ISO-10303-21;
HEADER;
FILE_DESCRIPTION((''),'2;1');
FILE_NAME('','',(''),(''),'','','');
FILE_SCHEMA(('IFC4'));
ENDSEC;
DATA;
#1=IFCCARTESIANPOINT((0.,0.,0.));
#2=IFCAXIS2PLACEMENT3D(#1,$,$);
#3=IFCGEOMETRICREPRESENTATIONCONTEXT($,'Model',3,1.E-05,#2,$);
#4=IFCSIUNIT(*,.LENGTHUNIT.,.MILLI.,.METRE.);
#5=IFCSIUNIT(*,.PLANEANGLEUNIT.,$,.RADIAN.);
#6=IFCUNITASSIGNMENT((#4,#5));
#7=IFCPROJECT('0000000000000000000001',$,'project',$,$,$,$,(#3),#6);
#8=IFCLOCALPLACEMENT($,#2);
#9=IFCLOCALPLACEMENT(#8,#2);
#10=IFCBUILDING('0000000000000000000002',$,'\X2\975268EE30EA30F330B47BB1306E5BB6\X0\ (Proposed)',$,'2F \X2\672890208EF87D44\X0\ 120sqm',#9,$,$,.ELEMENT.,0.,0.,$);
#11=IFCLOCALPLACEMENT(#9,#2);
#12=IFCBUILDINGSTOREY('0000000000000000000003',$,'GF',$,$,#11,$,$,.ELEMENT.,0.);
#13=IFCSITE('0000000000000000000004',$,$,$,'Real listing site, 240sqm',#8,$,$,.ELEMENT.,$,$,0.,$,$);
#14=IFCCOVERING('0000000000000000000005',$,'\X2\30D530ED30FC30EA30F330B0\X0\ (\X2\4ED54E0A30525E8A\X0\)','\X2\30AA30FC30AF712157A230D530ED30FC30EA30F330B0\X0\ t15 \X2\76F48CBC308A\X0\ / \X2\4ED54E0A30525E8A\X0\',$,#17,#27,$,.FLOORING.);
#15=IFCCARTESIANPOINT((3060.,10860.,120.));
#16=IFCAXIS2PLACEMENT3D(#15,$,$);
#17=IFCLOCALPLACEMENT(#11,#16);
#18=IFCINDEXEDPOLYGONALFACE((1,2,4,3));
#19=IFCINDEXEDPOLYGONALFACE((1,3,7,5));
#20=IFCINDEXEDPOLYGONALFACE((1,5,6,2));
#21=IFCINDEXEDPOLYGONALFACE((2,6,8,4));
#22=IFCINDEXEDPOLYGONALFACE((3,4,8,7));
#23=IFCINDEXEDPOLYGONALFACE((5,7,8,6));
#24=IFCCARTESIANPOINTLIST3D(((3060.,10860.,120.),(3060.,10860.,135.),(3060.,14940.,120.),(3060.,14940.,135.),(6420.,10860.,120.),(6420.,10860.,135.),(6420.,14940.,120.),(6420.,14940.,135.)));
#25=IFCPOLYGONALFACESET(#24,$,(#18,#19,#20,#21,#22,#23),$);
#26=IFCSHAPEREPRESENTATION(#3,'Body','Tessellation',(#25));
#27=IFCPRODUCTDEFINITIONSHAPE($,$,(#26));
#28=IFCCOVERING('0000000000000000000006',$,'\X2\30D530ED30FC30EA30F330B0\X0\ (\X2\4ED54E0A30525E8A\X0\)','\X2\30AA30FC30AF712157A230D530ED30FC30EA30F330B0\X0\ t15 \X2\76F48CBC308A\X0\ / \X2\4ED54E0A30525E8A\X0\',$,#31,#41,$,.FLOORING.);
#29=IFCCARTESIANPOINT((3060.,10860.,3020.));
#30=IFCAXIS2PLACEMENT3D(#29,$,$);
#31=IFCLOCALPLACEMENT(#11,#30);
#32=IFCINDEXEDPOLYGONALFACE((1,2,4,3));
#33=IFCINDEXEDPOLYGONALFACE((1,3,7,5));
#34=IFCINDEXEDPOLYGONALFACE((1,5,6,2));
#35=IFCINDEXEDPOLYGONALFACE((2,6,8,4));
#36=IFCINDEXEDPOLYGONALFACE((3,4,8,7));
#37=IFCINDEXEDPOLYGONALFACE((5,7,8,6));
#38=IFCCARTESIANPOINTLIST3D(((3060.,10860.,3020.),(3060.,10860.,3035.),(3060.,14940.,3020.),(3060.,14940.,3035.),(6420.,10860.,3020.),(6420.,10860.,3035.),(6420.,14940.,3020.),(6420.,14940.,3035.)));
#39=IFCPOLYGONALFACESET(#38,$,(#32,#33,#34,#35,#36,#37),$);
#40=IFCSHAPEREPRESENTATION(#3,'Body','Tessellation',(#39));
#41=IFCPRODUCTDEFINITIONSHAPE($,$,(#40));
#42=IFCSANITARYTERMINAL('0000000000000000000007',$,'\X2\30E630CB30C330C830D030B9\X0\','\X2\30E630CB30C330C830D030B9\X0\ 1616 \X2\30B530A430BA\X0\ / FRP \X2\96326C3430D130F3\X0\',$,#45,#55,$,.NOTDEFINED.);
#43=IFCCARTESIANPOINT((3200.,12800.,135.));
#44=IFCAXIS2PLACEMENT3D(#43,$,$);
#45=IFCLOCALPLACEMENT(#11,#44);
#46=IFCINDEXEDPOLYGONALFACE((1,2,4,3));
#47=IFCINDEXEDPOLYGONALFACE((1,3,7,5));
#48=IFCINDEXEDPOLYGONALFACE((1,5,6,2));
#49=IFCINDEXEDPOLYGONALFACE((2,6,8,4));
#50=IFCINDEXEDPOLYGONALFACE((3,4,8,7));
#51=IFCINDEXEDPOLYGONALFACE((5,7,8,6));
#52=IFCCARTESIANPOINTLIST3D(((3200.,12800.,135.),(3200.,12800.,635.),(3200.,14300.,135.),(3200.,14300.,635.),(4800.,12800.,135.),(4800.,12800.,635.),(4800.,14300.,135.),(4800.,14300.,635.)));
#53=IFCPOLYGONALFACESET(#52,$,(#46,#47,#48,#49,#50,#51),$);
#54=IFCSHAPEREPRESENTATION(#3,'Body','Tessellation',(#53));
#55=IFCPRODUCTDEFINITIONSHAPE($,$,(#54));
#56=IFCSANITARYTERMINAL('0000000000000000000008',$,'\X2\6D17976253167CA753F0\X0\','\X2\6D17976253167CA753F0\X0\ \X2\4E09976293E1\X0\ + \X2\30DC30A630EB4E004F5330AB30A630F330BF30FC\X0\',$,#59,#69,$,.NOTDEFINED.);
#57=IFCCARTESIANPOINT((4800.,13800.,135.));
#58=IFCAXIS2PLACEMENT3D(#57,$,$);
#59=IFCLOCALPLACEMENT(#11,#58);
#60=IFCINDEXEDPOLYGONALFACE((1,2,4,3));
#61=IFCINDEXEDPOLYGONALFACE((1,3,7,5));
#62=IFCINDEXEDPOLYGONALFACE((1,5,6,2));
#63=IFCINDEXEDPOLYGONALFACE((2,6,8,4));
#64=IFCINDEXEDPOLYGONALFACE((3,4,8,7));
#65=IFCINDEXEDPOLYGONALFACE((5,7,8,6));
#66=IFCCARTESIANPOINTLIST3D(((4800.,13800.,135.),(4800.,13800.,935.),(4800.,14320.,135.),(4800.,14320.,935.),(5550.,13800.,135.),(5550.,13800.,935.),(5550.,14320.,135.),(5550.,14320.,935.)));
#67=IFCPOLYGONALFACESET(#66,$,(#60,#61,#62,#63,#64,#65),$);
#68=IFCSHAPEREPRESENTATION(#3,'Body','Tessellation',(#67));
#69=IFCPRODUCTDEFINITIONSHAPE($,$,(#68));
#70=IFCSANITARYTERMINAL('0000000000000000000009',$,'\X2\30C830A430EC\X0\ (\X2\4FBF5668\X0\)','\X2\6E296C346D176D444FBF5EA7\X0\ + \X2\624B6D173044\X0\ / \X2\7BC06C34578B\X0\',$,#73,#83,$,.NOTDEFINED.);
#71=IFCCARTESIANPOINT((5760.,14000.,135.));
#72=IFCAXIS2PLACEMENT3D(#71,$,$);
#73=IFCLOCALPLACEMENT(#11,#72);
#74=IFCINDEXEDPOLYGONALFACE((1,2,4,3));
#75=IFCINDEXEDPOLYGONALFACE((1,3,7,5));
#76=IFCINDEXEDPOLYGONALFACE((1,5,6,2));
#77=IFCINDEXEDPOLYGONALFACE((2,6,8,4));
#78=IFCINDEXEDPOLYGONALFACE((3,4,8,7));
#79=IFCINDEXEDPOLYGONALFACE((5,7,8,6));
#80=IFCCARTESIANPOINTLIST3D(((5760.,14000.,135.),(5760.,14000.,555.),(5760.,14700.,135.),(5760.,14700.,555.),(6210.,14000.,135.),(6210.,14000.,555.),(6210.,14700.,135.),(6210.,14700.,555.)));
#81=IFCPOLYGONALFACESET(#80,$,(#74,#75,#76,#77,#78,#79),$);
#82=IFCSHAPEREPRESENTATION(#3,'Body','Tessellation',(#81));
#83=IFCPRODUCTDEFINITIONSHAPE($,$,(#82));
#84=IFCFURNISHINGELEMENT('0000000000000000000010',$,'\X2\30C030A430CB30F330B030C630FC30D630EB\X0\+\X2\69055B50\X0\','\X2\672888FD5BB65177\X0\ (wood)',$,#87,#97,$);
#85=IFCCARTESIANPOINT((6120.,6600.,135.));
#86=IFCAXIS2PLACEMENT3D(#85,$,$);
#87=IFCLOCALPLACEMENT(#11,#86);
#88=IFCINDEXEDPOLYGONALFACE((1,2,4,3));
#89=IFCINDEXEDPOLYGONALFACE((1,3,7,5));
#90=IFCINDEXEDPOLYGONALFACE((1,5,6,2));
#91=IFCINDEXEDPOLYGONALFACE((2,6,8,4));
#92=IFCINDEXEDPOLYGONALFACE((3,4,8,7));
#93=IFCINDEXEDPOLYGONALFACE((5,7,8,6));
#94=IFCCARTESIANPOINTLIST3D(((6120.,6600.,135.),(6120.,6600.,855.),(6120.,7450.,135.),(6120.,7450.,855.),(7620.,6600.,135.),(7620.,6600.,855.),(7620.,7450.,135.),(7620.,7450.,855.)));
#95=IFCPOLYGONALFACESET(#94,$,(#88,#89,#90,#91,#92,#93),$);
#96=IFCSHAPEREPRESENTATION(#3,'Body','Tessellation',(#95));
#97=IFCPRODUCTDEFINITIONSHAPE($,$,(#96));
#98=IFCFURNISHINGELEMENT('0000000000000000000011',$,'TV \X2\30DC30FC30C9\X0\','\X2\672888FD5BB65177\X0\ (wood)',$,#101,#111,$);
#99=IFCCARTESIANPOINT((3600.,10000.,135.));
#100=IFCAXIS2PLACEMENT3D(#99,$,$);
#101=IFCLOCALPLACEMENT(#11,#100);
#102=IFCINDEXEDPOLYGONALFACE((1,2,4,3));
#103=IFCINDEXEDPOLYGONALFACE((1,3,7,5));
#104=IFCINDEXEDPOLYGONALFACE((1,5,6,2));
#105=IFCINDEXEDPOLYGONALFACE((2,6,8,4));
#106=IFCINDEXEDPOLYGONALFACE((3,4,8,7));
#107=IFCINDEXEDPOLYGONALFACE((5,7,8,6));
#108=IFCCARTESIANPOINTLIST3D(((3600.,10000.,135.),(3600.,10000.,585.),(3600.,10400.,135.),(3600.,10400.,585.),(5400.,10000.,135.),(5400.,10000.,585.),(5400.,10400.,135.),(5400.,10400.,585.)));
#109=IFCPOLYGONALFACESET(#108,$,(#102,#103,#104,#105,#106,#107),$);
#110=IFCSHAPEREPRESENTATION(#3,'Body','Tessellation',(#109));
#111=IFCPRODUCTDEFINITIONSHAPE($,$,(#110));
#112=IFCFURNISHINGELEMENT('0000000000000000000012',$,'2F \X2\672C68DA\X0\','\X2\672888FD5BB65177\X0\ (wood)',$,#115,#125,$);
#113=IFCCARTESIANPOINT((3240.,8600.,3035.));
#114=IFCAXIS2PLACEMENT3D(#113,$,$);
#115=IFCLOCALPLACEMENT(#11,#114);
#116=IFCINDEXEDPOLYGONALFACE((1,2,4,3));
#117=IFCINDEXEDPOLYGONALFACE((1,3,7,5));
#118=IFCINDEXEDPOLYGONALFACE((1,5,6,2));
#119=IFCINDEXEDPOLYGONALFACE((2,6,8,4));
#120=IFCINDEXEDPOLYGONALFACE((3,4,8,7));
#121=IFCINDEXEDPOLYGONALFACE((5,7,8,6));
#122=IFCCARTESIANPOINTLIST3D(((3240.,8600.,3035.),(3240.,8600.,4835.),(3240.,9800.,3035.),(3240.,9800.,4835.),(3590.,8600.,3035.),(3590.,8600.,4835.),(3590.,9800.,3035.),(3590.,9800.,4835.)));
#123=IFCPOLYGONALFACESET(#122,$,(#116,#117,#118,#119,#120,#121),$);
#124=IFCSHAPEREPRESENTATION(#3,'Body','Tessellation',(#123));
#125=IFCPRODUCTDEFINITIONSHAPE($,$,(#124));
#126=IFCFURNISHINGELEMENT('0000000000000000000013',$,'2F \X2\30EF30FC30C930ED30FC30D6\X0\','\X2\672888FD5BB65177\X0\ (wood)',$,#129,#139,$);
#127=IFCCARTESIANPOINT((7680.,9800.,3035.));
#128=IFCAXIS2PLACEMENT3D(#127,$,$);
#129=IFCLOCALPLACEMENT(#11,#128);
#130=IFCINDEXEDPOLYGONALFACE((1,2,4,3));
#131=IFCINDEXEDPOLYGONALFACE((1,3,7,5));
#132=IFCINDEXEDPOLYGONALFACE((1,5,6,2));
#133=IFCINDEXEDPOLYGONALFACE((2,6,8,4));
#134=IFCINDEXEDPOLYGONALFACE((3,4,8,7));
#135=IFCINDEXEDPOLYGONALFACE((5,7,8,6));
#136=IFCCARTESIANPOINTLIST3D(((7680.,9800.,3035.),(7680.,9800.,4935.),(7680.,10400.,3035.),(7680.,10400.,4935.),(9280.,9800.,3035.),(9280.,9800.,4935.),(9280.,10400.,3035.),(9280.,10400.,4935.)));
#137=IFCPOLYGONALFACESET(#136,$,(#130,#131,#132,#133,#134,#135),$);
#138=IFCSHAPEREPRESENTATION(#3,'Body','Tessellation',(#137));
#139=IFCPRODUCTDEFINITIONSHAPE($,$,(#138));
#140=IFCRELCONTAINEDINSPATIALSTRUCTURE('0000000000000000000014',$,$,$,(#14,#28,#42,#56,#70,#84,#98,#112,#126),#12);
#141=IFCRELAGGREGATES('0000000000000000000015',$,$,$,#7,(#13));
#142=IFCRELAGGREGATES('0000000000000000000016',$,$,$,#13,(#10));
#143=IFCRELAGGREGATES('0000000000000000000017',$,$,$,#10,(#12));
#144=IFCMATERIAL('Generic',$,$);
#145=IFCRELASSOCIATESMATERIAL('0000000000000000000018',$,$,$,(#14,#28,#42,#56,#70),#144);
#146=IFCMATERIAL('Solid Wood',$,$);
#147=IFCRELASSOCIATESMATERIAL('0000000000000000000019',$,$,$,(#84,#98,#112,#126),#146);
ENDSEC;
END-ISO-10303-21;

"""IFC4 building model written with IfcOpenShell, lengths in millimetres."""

from ifc_helpers import new_model, si_unit, frame, frame_2d, origin, place, context, project, spatial, rectangle, extrude, material, element, save


model = new_model("IFC4")

# Units and contexts
model_context = context("Model", 3, precision=1e-05, world=origin())
ifc_project = project(units=[si_unit("LENGTHUNIT", "METRE", prefix="MILLI"), si_unit("PLANEANGLEUNIT", "RADIAN")], contexts=[model_context])

# Site, building, storey
site_placement = place(None, origin())
site = spatial("IfcSite", under=ifc_project, at=site_placement, ObjectType="Real listing site, 240sqm", CompositionType="ELEMENT", RefElevation=0.0)
building_placement = place(site_placement, origin())
building = spatial("IfcBuilding", under=site, at=building_placement, Name="青森リンゴ箱の家 (Proposed)", ObjectType="2F 木造軸組 120sqm", CompositionType="ELEMENT", ElevationOfRefHeight=0.0, ElevationOfTerrain=0.0)
storey_placement = place(building_placement, origin())
storey = spatial("IfcBuildingStorey", under=building, at=storey_placement, Name="GF", CompositionType="ELEMENT", Elevation=0.0)

# Shared definitions
ifc_material_1 = material(Name="Solid Wood")

# Coverings
ifc_material_2 = material(Name="Generic")
covering_1_placement = place(storey_placement, frame((3060.0, 10860.0, 120.0)))
element("IfcCovering", 1, at=covering_1_placement, inside=storey, material=ifc_material_2, Name="フローリング (仕上げ床)", Description="オーク無垢フローリング t15 直貼り / 仕上げ床", PredefinedType="FLOORING", context=model_context, shape_type="SweptSolid", body=[
    extrude(rectangle(XDim=3360.0, YDim=4080.0, at=frame_2d((1680.0, 2040.0))), frame((3060.0, 10860.0, 120.0)), (0.0, 0.0, 1.0), 15.0),
])
covering_2_placement = place(storey_placement, frame((3060.0, 10860.0, 3020.0)))
element("IfcCovering", 2, at=covering_2_placement, inside=storey, material=ifc_material_2, Name="フローリング (仕上げ床)", Description="オーク無垢フローリング t15 直貼り / 仕上げ床", PredefinedType="FLOORING", context=model_context, shape_type="SweptSolid", body=[
    extrude(rectangle(XDim=3360.0, YDim=4080.0, at=frame_2d((1680.0, 2040.0))), frame((3060.0, 10860.0, 3020.0)), (0.0, 0.0, 1.0), 15.0),
])

# Sanitary terminals
sanitary_terminal_1_placement = place(storey_placement, frame((3200.0, 12800.0, 135.0)))
element("IfcSanitaryTerminal", 3, at=sanitary_terminal_1_placement, inside=storey, material=ifc_material_2, Name="ユニットバス", Description="ユニットバス 1616 サイズ / FRP 防水パン", PredefinedType="NOTDEFINED", context=model_context, shape_type="SweptSolid", body=[
    extrude(rectangle(XDim=1600.0, YDim=1500.0, at=frame_2d((800.0, 750.0))), frame((3200.0, 12800.0, 135.0)), (0.0, 0.0, 1.0), 500.0),
])
sanitary_terminal_2_placement = place(storey_placement, frame((4800.0, 13800.0, 135.0)))
element("IfcSanitaryTerminal", 4, at=sanitary_terminal_2_placement, inside=storey, material=ifc_material_2, Name="洗面化粧台", Description="洗面化粧台 三面鏡 + ボウル一体カウンター", PredefinedType="NOTDEFINED", context=model_context, shape_type="SweptSolid", body=[
    extrude(rectangle(XDim=750.0, YDim=520.0, at=frame_2d((375.0, 260.0))), frame((4800.0, 13800.0, 135.0)), (0.0, 0.0, 1.0), 800.0),
])
sanitary_terminal_3_placement = place(storey_placement, frame((5760.0, 14000.0, 135.0)))
element("IfcSanitaryTerminal", 5, at=sanitary_terminal_3_placement, inside=storey, material=ifc_material_2, Name="トイレ (便器)", Description="温水洗浄便座 + 手洗い / 節水型", PredefinedType="NOTDEFINED", context=model_context, shape_type="SweptSolid", body=[
    extrude(rectangle(XDim=450.0, YDim=700.0, at=frame_2d((225.0, 350.0))), frame((5760.0, 14000.0, 135.0)), (0.0, 0.0, 1.0), 420.0),
])

# Furnishing elements
furnishing_1_placement = place(storey_placement, frame((6120.0, 6600.0, 135.0)))
element("IfcFurnishingElement", 6, at=furnishing_1_placement, inside=storey, material=ifc_material_1, Name="ダイニングテーブル+椅子", Description="木製家具 (wood)", context=model_context, shape_type="SweptSolid", body=[
    extrude(rectangle(XDim=1500.0, YDim=850.0, at=frame_2d((750.0, 425.0))), frame((6120.0, 6600.0, 135.0)), (0.0, 0.0, 1.0), 720.0),
])
furnishing_2_placement = place(storey_placement, frame((3600.0, 10000.0, 135.0)))
element("IfcFurnishingElement", 7, at=furnishing_2_placement, inside=storey, material=ifc_material_1, Name="TV ボード", Description="木製家具 (wood)", context=model_context, shape_type="SweptSolid", body=[
    extrude(rectangle(XDim=1800.0, YDim=400.0, at=frame_2d((900.0, 200.0))), frame((3600.0, 10000.0, 135.0)), (0.0, 0.0, 1.0), 450.0),
])
furnishing_3_placement = place(storey_placement, frame((3240.0, 8600.0, 3035.0)))
element("IfcFurnishingElement", 8, at=furnishing_3_placement, inside=storey, material=ifc_material_1, Name="2F 本棚", Description="木製家具 (wood)", context=model_context, shape_type="SweptSolid", body=[
    extrude(rectangle(XDim=350.0, YDim=1200.0, at=frame_2d((175.0, 600.0))), frame((3240.0, 8600.0, 3035.0)), (0.0, 0.0, 1.0), 1800.0),
])
furnishing_4_placement = place(storey_placement, frame((7680.0, 9800.0, 3035.0)))
element("IfcFurnishingElement", 9, at=furnishing_4_placement, inside=storey, material=ifc_material_1, Name="2F ワードローブ", Description="木製家具 (wood)", context=model_context, shape_type="SweptSolid", body=[
    extrude(rectangle(XDim=1600.0, YDim=600.0, at=frame_2d((800.0, 300.0))), frame((7680.0, 9800.0, 3035.0)), (0.0, 0.0, 1.0), 1900.0),
])

save(model, "model.ifc")
